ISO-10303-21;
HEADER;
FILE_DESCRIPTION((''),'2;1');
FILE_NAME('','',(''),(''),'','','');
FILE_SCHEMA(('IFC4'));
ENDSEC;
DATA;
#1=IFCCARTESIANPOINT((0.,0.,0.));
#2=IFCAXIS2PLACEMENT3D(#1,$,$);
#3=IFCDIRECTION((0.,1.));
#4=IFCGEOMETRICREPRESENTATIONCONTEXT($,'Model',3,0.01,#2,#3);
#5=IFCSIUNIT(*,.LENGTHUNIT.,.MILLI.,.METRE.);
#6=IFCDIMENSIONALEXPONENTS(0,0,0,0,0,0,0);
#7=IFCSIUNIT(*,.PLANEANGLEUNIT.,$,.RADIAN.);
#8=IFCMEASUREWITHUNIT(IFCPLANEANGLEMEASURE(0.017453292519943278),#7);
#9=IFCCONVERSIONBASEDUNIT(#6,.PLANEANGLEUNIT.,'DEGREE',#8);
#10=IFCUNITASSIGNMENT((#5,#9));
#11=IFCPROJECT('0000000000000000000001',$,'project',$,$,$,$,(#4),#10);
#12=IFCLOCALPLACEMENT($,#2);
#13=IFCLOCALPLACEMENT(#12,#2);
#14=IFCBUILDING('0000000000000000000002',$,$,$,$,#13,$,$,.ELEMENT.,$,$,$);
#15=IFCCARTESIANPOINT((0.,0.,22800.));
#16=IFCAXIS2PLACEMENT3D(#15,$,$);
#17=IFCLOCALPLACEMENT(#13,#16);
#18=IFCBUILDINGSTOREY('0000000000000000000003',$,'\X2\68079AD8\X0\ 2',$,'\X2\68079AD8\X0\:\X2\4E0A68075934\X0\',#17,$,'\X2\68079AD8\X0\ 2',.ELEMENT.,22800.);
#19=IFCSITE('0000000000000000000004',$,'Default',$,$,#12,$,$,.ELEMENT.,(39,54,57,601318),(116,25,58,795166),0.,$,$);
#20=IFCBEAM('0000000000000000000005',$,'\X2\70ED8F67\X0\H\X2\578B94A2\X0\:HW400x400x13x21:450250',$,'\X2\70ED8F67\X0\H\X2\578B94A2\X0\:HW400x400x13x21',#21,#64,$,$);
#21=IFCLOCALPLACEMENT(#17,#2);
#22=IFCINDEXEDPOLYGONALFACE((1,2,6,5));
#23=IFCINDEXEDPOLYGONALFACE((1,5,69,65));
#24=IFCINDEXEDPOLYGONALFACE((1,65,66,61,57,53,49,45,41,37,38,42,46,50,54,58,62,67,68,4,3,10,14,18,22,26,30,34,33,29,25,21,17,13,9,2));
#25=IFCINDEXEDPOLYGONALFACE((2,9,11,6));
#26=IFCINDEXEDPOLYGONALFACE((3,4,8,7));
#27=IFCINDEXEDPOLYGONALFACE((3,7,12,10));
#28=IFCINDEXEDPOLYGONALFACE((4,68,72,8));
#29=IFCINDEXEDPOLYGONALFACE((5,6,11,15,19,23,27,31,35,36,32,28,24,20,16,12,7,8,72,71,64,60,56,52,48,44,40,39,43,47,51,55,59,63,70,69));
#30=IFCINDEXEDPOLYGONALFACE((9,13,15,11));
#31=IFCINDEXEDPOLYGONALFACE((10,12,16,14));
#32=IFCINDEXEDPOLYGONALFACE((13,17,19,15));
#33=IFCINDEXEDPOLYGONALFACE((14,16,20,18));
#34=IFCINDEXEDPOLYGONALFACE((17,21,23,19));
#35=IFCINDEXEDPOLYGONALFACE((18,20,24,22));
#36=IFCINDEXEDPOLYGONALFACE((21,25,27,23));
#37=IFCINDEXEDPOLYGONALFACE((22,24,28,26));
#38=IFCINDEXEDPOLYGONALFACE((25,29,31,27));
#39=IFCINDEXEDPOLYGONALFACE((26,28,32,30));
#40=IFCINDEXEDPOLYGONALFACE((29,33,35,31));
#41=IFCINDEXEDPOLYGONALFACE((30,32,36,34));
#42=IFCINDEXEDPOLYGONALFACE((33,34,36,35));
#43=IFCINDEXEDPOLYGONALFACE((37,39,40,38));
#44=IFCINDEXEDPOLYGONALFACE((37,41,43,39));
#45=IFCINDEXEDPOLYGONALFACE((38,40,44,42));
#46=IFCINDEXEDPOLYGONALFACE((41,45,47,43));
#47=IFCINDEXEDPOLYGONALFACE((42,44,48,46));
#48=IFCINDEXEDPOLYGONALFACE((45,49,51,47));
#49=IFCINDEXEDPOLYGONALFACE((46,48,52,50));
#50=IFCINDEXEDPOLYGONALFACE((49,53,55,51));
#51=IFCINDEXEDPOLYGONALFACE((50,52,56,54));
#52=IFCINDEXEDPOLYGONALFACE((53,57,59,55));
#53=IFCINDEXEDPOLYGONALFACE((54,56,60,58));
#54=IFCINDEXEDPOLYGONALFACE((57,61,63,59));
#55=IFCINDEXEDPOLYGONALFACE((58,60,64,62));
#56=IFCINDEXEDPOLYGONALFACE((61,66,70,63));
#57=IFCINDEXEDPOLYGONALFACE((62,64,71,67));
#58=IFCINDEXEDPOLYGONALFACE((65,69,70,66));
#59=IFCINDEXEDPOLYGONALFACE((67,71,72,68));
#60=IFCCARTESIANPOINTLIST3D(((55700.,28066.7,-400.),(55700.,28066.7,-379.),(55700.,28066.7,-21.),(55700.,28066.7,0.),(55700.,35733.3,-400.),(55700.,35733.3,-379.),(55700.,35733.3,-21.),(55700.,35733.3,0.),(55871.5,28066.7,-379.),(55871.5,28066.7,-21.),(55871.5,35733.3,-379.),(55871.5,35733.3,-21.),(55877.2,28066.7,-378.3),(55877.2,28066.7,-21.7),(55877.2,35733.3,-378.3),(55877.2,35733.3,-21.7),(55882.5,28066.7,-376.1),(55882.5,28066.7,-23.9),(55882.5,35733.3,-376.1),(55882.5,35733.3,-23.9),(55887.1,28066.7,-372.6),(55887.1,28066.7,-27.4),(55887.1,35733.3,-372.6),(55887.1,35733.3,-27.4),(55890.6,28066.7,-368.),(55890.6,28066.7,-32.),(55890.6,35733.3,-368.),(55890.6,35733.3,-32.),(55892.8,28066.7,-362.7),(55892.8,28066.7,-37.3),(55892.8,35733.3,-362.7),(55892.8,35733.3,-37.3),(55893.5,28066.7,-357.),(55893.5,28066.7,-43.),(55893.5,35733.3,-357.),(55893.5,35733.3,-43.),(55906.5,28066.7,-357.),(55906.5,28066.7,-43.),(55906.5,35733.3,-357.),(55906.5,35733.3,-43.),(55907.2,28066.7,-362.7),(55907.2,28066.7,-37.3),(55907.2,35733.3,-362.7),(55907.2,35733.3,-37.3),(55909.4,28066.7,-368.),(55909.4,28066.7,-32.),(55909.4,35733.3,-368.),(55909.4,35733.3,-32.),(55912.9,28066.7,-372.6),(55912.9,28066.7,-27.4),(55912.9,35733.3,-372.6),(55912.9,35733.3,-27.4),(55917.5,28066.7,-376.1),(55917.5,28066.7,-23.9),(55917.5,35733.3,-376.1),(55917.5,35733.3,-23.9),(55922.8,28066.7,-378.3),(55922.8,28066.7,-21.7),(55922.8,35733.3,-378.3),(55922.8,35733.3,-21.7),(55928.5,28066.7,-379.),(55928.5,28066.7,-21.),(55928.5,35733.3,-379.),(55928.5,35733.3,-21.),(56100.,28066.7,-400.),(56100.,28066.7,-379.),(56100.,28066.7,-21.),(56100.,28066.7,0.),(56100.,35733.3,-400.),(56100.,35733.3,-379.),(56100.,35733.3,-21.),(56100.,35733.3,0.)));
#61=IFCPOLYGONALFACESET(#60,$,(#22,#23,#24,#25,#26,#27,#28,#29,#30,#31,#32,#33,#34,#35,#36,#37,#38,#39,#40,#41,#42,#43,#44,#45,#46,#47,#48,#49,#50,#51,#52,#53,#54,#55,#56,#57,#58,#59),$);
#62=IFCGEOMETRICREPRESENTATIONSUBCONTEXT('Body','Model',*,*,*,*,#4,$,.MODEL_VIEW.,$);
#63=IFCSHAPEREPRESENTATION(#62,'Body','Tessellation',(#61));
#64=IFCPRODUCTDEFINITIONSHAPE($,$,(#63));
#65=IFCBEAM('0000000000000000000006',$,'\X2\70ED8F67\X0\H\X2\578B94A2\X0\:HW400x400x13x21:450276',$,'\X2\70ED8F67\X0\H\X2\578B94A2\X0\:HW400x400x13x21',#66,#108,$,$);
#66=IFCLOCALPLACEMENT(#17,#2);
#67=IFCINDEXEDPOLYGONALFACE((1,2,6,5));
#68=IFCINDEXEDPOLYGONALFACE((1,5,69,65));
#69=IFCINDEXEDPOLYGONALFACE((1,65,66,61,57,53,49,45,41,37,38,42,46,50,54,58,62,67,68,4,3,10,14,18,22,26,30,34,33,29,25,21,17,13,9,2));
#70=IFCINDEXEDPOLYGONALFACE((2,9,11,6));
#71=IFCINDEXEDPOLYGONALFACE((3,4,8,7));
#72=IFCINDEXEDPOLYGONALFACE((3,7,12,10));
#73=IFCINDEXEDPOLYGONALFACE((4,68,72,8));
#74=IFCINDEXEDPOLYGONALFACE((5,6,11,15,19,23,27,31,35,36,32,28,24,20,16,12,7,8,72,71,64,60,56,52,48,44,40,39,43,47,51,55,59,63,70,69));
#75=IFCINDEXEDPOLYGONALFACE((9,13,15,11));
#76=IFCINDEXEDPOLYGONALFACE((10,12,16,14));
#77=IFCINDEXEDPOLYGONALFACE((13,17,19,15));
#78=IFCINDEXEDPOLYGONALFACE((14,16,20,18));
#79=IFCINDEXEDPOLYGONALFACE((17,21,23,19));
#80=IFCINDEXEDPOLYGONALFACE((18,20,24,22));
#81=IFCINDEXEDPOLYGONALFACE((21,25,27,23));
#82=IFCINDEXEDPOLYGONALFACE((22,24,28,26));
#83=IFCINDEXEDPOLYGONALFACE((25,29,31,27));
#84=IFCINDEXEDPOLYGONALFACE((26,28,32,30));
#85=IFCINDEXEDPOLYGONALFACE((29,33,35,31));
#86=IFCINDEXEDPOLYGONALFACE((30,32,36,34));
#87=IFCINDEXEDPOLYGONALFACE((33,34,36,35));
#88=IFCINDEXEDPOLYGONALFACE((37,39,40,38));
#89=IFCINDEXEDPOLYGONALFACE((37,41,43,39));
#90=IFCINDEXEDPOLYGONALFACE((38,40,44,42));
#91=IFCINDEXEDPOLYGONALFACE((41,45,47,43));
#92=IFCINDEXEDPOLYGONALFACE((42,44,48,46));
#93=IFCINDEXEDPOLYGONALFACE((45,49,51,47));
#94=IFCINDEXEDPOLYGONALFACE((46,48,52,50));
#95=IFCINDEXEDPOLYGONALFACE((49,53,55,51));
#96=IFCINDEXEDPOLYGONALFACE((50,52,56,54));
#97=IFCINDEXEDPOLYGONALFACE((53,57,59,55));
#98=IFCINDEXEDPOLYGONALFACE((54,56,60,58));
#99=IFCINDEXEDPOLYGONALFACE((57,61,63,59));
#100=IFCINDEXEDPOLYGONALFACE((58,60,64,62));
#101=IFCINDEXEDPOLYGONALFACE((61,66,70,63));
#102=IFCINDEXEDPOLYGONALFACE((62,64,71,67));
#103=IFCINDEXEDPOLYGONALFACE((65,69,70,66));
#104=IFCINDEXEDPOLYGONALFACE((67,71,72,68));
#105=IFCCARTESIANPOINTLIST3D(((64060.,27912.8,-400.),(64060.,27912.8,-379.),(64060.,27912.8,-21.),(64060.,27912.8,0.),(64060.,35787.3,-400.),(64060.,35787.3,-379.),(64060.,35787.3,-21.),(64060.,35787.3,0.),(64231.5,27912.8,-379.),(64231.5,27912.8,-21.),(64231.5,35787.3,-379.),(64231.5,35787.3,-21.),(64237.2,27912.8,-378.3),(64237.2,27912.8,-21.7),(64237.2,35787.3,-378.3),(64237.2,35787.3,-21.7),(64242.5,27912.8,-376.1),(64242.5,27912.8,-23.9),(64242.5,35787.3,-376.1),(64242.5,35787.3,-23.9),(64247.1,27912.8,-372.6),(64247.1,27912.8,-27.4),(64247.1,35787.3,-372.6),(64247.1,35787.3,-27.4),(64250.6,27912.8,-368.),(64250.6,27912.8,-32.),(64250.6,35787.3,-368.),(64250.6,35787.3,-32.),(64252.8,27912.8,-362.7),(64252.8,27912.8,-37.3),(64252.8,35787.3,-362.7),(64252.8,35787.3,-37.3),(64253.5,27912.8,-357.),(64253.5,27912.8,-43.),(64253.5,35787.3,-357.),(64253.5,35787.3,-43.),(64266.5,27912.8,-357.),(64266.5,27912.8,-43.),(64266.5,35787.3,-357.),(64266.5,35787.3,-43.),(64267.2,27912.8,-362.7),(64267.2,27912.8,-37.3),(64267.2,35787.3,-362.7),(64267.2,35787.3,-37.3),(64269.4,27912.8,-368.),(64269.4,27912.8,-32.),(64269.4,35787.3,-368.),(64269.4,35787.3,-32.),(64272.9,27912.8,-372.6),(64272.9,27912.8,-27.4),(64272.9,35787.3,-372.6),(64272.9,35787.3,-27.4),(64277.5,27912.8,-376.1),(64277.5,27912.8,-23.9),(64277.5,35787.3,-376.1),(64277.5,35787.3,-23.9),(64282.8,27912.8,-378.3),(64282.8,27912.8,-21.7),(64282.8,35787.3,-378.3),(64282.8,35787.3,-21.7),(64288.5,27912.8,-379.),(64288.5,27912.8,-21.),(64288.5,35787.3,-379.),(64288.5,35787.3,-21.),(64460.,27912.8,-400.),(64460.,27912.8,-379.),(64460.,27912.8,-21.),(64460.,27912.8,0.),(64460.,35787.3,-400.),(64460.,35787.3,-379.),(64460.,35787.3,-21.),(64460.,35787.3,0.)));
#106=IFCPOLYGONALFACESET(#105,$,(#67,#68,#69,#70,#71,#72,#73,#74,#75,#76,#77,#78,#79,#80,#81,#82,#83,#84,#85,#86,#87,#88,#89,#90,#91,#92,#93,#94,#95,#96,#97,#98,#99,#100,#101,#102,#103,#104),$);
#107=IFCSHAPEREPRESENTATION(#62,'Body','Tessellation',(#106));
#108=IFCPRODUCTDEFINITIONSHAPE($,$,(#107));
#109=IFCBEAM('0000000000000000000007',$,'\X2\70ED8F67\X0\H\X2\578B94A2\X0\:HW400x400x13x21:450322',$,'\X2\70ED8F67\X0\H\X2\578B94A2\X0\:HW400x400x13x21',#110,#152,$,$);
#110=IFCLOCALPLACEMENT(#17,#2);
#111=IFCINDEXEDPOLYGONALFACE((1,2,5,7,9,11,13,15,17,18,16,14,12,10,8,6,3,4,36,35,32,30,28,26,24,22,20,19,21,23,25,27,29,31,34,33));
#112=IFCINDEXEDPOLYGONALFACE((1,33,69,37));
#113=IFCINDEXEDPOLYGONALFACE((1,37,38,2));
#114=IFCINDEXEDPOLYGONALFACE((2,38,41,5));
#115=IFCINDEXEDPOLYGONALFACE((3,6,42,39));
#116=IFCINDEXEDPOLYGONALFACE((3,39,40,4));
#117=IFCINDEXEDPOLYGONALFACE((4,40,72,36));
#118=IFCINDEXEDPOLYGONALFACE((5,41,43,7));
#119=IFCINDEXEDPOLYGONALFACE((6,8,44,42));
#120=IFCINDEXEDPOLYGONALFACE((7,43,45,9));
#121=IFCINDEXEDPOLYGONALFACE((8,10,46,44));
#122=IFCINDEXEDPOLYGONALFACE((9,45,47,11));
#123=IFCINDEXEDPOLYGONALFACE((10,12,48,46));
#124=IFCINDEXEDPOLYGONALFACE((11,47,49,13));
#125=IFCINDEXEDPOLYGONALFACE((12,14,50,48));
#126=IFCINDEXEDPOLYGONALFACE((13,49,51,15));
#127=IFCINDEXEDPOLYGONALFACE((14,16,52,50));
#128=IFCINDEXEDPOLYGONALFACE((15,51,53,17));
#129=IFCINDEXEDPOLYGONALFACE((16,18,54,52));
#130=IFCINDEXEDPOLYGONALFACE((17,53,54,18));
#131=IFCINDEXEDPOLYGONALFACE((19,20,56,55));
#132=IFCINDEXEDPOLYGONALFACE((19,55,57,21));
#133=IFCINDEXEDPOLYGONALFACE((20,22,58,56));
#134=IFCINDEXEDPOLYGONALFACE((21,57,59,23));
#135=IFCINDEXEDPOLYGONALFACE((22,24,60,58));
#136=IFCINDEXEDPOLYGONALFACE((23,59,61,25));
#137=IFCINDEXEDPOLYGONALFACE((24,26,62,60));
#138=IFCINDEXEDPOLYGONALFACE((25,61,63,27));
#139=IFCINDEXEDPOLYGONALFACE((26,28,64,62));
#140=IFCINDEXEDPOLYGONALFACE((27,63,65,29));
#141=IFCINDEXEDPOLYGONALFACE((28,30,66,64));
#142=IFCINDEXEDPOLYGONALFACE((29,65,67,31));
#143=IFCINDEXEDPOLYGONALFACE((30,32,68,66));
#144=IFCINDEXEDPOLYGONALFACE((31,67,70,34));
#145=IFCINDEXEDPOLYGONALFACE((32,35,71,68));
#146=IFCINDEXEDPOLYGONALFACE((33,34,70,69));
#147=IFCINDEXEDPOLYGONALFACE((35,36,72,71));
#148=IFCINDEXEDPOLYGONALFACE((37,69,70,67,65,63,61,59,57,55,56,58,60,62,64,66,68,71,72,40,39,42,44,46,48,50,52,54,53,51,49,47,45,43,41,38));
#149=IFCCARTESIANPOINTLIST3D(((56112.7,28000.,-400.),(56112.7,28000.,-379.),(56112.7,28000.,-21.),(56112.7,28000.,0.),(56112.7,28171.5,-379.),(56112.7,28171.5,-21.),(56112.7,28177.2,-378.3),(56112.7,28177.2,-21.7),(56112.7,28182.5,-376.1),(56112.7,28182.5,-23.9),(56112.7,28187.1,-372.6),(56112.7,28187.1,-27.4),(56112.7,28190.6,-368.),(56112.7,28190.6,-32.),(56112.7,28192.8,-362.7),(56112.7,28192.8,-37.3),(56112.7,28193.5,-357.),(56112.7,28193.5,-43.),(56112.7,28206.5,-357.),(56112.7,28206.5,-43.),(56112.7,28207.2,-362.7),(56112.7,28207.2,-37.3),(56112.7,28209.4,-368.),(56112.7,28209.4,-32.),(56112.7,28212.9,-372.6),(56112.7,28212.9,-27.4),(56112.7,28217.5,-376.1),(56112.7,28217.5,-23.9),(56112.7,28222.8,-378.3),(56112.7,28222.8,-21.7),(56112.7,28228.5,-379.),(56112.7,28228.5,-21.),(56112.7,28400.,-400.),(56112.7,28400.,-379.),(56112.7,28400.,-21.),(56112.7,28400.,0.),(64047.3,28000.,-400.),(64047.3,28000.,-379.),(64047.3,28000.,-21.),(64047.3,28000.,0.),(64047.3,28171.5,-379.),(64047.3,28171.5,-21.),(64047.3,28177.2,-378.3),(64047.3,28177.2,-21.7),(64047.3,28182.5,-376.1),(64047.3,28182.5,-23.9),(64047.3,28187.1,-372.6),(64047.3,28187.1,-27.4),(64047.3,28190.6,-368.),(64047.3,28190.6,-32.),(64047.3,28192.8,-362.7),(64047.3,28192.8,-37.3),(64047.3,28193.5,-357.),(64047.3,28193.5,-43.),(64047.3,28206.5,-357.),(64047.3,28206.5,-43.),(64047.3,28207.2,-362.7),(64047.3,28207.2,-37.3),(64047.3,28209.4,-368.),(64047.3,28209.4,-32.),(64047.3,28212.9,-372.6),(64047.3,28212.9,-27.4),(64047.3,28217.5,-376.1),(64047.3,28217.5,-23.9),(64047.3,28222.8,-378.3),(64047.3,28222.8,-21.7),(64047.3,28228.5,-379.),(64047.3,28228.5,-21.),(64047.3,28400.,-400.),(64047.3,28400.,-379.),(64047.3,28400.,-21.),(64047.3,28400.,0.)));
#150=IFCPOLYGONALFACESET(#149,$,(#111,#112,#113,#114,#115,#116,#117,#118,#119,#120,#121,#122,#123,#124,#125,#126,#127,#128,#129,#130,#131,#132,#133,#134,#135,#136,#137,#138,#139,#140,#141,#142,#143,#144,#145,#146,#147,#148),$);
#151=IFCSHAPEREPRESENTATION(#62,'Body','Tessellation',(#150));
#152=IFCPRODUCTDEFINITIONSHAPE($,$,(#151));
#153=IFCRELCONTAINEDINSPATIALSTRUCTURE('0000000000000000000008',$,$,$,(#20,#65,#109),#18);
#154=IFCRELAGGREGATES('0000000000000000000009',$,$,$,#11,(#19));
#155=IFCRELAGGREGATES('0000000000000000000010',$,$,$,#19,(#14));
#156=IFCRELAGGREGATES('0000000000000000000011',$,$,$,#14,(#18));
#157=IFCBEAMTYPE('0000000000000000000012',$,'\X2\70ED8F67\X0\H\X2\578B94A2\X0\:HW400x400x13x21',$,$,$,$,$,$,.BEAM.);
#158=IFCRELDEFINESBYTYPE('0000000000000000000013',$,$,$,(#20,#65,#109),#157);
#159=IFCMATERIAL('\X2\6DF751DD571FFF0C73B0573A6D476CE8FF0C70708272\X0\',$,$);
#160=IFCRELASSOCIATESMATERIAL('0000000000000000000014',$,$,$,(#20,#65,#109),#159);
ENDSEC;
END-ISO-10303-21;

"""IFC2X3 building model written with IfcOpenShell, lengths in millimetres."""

from ifc_helpers import new_model, entity, si_unit, converted_unit, direction, frame, frame_2d, origin, place, context, subcontext, project, spatial, i_section, extrude, material, type_object, element, save


model = new_model("IFC2X3")

# Units and contexts
model_context = context("Model", 3, precision=0.01, world=origin(), true_north=direction((0.0, 1.0)))
body_context = subcontext(model_context, "Body", "Model", "MODEL_VIEW")
ifc_project = project(units=[si_unit("LENGTHUNIT", "METRE", prefix="MILLI"), converted_unit("PLANEANGLEUNIT", "DEGREE", entity("IfcPlaneAngleMeasure", 0.017453292519943278), si_unit("PLANEANGLEUNIT", "RADIAN"), dimensions=[0, 0, 0, 0, 0, 0, 0])], contexts=[model_context])

# Site, building, storey
site_placement = place(None, origin())
site = spatial("IfcSite", under=ifc_project, at=site_placement, Name="Default", CompositionType="ELEMENT", RefLatitude=(39, 54, 57, 601318), RefLongitude=(116, 25, 58, 795166), RefElevation=0.0)
building_placement = place(site_placement, origin())
building = spatial("IfcBuilding", under=site, at=building_placement, CompositionType="ELEMENT")
storey_placement = place(building_placement, frame((0.0, 0.0, 22800.0)))
storey = spatial("IfcBuildingStorey", under=building, at=storey_placement, Name="标高 2", ObjectType="标高:上标头", LongName="标高 2", CompositionType="ELEMENT", Elevation=22800.0)

# Beams
ifc_material = material(Name="混凝土，现场浇注，灰色")
beam_type = type_object("IfcBeamType", Name="热轧H型钢:HW400x400x13x21", PredefinedType="BEAM")
beam_1_placement = place(storey_placement, frame((55900.0, 36000.0, 0.0), z_axis=(0.0, 0.0, 1.0), x_axis=(0.0, -1.0, 0.0)))
element("IfcBeam", 1, at=beam_1_placement, inside=storey, type_object=beam_type, material=ifc_material, Name="热轧H型钢:HW400x400x13x21:450250", ObjectType="热轧H型钢:HW400x400x13x21", context=body_context, shape_type="SweptSolid", body=[
    extrude(i_section(OverallWidth=400.0, OverallDepth=400.0, WebThickness=13.0, FlangeThickness=21.0, FilletRadius=22.0, at=frame_2d((0.0, 0.0), x_axis=(0.0, 1.0))), frame((266.7, 0.0, -200.0), z_axis=(1.0, 0.0, 0.0), x_axis=(0.0, 0.0, -1.0)), (0.0, 0.0, 1.0), 7666.6),
])
beam_2_placement = place(storey_placement, frame((64260.0, 36000.0, 0.0), z_axis=(0.0, 0.0, 1.0), x_axis=(0.0, -1.0, 0.0)))
element("IfcBeam", 2, at=beam_2_placement, inside=storey, type_object=beam_type, material=ifc_material, Name="热轧H型钢:HW400x400x13x21:450276", ObjectType="热轧H型钢:HW400x400x13x21", context=body_context, shape_type="SweptSolid", body=[
    extrude(i_section(OverallWidth=400.0, OverallDepth=400.0, WebThickness=13.0, FlangeThickness=21.0, FilletRadius=22.0, at=frame_2d((0.0, 0.0), x_axis=(0.0, 1.0))), frame((212.7, 0.0, -200.0), z_axis=(1.0, 0.0, 0.0), x_axis=(0.0, 0.0, -1.0)), (0.0, 0.0, 1.0), 7874.5),
])
beam_3_placement = place(storey_placement, frame((55900.0, 28200.0, 0.0)))
element("IfcBeam", 3, at=beam_3_placement, inside=storey, type_object=beam_type, material=ifc_material, Name="热轧H型钢:HW400x400x13x21:450322", ObjectType="热轧H型钢:HW400x400x13x21", context=body_context, shape_type="SweptSolid", body=[
    extrude(i_section(OverallWidth=400.0, OverallDepth=400.0, WebThickness=13.0, FlangeThickness=21.0, FilletRadius=22.0, at=frame_2d((0.0, 0.0), x_axis=(0.0, 1.0))), frame((212.7, 0.0, -200.0), z_axis=(1.0, 0.0, 0.0), x_axis=(0.0, 0.0, -1.0)), (0.0, 0.0, 1.0), 7934.6),
])

save(model, "model.ifc")
